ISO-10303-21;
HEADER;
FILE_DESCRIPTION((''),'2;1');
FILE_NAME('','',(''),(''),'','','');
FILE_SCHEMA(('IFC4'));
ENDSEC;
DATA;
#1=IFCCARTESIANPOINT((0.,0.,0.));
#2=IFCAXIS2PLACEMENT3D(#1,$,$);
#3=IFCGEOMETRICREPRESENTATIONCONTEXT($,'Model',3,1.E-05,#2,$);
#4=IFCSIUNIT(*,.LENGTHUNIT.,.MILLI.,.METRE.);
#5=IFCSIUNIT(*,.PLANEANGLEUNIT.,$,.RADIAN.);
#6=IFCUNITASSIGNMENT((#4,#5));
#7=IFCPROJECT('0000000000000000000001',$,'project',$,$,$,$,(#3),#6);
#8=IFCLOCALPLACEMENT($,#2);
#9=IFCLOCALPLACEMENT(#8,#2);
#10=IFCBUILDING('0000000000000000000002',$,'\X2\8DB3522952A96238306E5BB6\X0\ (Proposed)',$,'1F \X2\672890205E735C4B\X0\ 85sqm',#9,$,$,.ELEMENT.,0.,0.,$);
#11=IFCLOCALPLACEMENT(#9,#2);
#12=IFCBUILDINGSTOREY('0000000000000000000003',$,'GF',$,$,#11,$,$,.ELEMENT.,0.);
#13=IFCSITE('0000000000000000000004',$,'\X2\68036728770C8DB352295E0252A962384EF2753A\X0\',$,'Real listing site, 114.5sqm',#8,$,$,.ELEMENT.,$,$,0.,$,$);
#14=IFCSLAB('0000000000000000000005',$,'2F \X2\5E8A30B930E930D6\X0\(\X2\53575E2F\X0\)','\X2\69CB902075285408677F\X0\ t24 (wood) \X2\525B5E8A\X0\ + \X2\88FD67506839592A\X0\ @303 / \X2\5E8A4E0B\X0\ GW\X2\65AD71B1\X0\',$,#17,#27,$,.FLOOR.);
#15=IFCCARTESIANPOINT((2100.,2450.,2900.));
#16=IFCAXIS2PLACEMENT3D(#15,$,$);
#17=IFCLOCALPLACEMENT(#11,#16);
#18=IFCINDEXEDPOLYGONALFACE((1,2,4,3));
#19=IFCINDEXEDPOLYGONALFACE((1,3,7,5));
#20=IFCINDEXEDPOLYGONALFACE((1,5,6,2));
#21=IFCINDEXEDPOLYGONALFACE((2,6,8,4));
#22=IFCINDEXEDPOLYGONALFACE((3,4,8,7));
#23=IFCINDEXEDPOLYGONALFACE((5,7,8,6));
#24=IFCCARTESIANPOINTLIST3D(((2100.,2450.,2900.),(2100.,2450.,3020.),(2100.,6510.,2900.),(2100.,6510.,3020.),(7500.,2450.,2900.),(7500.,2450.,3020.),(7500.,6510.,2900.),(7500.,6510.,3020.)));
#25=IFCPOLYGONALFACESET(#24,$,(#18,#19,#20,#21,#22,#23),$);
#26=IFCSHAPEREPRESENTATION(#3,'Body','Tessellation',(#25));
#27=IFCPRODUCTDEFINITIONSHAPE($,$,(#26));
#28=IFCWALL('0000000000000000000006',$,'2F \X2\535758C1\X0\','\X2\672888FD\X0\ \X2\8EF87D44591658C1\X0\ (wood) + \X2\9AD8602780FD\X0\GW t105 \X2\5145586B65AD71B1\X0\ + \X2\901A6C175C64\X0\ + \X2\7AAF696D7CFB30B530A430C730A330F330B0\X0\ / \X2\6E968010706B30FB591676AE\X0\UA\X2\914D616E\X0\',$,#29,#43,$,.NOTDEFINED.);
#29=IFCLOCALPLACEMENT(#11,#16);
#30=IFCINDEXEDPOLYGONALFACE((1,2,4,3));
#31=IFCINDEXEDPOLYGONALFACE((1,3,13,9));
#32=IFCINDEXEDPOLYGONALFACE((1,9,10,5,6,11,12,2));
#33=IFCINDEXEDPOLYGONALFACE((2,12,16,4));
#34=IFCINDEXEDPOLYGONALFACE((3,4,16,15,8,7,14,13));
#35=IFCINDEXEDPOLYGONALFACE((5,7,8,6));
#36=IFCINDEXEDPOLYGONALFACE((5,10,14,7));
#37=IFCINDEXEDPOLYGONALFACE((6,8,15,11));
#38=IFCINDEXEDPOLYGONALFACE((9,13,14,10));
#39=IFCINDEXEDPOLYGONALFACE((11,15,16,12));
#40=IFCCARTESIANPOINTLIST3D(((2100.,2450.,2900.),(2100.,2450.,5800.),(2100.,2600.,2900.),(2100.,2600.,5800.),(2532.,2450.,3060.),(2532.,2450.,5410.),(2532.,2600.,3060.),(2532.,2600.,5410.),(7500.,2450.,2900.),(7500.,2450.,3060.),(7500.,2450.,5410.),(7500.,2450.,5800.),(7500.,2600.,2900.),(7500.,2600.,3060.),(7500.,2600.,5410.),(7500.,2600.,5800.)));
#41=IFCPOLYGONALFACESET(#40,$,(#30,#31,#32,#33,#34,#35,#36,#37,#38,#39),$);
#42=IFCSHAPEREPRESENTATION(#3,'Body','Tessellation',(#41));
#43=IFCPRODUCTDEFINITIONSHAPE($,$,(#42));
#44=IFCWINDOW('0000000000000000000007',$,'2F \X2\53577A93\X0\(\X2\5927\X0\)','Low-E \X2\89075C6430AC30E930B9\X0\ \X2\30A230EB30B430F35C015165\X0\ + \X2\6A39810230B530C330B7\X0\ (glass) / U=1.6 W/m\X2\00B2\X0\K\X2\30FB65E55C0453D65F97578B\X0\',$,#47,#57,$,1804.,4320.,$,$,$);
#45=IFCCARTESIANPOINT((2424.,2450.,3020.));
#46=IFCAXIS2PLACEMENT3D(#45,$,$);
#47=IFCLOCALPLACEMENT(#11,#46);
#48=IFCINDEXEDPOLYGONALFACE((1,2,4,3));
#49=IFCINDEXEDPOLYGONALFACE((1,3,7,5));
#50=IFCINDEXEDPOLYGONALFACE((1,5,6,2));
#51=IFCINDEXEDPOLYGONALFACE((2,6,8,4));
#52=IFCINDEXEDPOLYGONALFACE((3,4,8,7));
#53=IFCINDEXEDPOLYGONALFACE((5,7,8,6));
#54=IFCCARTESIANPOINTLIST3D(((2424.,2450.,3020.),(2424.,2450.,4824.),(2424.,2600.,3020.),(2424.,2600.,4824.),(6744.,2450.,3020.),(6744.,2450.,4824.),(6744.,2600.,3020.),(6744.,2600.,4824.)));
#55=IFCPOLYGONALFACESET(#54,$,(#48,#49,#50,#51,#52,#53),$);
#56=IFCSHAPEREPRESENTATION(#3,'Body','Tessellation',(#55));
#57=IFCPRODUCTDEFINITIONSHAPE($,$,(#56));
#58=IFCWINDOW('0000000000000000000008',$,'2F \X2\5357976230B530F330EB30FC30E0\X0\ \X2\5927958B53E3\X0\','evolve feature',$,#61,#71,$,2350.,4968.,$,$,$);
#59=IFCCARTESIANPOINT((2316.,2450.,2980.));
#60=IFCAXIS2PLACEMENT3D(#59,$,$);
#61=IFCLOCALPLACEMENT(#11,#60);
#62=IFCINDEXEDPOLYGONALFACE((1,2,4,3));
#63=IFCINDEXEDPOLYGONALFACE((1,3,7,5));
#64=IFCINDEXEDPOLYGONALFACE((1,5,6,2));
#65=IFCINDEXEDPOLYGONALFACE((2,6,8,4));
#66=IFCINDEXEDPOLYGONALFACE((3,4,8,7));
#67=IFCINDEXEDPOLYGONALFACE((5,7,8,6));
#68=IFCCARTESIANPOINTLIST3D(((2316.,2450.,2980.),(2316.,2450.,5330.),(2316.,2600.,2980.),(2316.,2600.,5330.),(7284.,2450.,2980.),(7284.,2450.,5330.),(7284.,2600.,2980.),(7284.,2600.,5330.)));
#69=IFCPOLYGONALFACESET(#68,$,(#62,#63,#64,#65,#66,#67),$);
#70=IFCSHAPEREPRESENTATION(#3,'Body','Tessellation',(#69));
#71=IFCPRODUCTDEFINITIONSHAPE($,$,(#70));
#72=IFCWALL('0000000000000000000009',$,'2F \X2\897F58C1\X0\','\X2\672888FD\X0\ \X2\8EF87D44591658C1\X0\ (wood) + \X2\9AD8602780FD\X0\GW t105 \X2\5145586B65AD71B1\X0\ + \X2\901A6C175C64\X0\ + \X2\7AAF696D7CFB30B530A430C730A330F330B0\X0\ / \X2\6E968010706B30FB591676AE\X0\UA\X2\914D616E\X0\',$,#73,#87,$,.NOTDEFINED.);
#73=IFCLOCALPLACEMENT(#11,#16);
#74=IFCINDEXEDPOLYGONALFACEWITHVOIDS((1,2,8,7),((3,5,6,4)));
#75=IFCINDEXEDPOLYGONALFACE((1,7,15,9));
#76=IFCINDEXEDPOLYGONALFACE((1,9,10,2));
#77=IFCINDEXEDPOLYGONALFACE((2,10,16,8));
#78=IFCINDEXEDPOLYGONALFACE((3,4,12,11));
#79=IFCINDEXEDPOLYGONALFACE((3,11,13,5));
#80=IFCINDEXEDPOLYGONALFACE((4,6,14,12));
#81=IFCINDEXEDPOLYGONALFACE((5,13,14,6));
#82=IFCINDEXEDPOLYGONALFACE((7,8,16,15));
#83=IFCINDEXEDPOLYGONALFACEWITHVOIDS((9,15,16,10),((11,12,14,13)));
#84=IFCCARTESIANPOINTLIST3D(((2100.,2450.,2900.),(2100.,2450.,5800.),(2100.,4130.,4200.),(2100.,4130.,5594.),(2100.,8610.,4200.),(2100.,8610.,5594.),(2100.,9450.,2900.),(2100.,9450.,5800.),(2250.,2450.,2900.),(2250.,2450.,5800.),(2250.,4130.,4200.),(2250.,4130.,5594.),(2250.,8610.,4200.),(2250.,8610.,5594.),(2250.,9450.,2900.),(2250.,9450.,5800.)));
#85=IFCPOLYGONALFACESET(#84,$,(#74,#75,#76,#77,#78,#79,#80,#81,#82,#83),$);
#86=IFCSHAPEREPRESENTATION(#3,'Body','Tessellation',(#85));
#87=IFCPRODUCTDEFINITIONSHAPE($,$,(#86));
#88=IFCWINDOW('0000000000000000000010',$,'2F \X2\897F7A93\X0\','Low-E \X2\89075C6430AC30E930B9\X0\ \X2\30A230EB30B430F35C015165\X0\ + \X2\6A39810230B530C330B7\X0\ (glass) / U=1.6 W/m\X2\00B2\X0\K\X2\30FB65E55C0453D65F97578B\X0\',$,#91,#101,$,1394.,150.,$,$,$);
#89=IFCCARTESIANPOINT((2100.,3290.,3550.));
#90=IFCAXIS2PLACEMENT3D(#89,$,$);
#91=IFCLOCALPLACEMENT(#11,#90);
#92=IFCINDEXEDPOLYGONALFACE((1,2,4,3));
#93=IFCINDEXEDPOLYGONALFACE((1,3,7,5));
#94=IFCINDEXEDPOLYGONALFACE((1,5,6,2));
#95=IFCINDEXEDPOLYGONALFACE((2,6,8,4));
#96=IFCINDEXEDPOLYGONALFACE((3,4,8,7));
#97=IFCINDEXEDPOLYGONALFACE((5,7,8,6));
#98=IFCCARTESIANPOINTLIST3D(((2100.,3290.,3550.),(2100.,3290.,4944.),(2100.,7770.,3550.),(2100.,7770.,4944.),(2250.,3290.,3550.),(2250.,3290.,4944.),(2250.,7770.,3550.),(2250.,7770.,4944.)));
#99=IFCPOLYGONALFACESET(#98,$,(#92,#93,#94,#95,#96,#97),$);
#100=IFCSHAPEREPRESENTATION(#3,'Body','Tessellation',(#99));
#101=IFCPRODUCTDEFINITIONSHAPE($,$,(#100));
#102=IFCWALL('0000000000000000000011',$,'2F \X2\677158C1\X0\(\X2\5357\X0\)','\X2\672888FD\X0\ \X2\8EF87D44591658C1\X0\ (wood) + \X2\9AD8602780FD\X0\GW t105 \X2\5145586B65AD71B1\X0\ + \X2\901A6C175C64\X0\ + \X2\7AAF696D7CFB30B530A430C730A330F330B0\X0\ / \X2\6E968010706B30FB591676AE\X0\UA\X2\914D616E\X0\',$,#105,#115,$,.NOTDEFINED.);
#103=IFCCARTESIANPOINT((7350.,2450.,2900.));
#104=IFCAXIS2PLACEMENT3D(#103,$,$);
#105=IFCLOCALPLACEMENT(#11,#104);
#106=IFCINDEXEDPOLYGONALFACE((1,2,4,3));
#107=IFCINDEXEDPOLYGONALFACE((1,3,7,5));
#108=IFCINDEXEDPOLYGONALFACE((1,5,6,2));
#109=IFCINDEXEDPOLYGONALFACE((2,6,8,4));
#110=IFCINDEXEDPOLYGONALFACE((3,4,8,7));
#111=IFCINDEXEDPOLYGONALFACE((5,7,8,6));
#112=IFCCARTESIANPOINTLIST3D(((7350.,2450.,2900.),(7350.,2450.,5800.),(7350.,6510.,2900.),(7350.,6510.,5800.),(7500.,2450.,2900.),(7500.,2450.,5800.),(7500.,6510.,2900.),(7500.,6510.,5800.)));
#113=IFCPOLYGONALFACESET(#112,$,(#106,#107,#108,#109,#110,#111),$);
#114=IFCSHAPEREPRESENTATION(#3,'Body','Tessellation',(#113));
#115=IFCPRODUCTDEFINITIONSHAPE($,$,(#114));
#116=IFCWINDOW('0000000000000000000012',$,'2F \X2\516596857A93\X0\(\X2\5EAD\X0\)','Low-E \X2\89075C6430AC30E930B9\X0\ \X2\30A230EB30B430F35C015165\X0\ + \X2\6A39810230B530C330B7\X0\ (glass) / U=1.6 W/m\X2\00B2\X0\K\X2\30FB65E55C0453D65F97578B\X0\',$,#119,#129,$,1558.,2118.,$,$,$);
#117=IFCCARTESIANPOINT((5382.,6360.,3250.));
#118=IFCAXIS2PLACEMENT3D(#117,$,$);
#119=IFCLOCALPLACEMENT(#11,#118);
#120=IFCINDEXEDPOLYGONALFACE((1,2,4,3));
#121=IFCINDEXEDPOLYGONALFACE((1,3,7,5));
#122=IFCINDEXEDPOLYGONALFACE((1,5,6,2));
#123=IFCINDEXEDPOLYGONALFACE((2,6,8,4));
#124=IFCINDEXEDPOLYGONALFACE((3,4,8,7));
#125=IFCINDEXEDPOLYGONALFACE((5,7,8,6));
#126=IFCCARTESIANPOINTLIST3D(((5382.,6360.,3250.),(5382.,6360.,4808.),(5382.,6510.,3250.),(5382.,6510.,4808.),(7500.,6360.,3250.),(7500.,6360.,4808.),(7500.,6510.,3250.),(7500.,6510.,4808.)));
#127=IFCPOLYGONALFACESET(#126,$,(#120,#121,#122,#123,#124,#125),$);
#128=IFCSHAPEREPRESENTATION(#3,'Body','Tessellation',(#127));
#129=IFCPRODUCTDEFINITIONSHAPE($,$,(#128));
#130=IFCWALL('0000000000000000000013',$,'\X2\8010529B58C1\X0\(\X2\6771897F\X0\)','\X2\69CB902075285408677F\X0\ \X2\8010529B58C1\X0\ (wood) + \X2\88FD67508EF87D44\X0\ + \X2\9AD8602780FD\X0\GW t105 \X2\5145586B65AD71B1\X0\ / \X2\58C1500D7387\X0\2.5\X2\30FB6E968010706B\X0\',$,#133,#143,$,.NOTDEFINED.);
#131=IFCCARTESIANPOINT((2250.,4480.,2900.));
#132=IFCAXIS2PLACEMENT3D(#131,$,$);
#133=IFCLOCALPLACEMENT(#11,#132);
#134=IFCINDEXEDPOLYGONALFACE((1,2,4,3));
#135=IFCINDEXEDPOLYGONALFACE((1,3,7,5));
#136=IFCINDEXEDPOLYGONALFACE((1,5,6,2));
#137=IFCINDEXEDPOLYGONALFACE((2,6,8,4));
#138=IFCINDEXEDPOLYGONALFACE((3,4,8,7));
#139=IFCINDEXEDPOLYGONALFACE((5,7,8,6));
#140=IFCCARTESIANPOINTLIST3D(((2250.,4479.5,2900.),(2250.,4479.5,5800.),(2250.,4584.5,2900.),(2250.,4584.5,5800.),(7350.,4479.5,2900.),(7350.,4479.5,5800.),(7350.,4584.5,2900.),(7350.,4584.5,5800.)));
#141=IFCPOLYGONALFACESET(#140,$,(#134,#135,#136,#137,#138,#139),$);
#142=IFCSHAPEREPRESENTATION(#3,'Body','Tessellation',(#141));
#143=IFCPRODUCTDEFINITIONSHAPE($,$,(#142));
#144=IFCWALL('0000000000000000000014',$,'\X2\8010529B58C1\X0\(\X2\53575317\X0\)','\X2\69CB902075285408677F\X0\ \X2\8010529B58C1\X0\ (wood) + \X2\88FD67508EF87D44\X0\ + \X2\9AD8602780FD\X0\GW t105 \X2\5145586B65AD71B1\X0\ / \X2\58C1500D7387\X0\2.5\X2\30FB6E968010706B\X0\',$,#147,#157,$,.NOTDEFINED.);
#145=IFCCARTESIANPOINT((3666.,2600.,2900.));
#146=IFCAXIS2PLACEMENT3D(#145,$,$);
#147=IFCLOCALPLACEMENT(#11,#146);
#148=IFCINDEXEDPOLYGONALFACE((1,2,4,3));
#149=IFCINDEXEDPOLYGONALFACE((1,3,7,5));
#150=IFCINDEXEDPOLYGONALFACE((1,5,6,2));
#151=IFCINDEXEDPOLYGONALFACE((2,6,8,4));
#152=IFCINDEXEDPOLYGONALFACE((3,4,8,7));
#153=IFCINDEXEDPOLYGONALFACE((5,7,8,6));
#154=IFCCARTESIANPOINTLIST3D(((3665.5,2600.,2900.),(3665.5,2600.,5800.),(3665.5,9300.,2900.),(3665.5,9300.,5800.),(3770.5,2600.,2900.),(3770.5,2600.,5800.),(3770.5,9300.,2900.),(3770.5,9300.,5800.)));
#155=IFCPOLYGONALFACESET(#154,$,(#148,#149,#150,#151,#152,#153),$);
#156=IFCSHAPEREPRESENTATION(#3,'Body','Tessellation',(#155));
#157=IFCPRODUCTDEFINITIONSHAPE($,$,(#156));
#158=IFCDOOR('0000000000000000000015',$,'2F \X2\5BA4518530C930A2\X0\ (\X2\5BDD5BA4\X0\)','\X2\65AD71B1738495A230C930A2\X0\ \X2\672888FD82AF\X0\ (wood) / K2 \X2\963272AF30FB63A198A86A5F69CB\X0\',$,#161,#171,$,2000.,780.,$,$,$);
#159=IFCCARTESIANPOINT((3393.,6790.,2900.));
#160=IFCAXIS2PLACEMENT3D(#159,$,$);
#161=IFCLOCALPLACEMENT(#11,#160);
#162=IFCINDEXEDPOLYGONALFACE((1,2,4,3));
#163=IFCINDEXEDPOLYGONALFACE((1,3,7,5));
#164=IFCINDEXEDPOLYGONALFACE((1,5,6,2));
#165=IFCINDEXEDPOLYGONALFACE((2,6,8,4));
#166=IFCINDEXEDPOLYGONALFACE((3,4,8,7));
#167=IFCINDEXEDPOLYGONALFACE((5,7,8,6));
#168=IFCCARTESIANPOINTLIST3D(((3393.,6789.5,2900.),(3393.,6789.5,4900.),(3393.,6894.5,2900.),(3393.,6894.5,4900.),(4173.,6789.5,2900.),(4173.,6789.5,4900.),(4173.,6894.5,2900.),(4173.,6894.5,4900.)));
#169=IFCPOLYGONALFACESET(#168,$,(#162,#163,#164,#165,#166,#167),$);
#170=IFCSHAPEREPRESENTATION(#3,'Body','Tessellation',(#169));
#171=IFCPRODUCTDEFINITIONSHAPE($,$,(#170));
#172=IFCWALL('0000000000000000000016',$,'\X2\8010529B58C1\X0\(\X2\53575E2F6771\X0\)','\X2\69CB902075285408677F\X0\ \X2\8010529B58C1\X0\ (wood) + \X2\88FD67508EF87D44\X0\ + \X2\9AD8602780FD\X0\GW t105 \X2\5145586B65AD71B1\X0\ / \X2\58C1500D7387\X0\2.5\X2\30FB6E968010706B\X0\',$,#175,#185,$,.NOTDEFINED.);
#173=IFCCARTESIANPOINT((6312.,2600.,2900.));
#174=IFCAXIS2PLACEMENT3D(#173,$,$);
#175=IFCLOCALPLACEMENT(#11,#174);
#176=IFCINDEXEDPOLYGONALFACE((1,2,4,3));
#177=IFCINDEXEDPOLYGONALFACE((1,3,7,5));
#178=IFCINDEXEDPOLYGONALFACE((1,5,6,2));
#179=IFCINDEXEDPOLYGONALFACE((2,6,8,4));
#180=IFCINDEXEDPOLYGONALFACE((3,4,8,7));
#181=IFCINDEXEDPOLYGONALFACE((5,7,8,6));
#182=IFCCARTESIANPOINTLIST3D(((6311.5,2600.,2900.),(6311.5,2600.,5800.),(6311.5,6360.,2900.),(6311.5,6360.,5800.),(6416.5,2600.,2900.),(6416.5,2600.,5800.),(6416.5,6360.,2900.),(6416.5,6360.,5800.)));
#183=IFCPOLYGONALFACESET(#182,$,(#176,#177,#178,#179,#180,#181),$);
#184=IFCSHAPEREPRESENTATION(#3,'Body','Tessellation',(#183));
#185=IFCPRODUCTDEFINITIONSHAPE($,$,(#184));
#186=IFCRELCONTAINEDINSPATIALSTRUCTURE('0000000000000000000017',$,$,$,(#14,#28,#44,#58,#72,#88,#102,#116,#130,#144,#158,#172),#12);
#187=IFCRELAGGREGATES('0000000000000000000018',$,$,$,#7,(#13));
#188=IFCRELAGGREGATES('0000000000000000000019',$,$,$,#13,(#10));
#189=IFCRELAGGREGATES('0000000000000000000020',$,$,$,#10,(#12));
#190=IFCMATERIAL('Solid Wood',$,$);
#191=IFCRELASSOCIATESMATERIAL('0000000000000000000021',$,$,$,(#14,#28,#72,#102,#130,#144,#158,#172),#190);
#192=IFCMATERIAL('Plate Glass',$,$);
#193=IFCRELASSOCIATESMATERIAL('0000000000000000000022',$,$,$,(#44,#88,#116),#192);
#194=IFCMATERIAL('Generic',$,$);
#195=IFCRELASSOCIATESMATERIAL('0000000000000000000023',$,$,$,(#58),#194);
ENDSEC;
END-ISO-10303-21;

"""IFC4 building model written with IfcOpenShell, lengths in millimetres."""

from ifc_helpers import new_model, si_unit, frame, frame_2d, origin, place, context, project, spatial, rectangle, extrude, material, element, fill, save


model = new_model("IFC4")

# Units and contexts
model_context = context("Model", 3, precision=1e-05, world=origin())
ifc_project = project(units=[si_unit("LENGTHUNIT", "METRE", prefix="MILLI"), si_unit("PLANEANGLEUNIT", "RADIAN")], contexts=[model_context])

# Site, building, storey
site_placement = place(None, origin())
site = spatial("IfcSite", under=ifc_project, at=site_placement, Name="栃木県足利市助戸仲町", ObjectType="Real listing site, 114.5sqm", CompositionType="ELEMENT", RefElevation=0.0)
building_placement = place(site_placement, origin())
building = spatial("IfcBuilding", under=site, at=building_placement, Name="足利助戸の家 (Proposed)", ObjectType="1F 木造平屋 85sqm", CompositionType="ELEMENT", ElevationOfRefHeight=0.0, ElevationOfTerrain=0.0)
storey_placement = place(building_placement, origin())
storey = spatial("IfcBuildingStorey", under=building, at=storey_placement, Name="GF", CompositionType="ELEMENT", Elevation=0.0)

# Slab
ifc_material_1 = material(Name="Solid Wood")
slab_placement = place(storey_placement, frame((2100.0, 2450.0, 2900.0)))
element("IfcSlab", 1, at=slab_placement, inside=storey, material=ifc_material_1, Name="2F 床スラブ(南帯)", Description="構造用合板 t24 (wood) 剛床 + 製材根太 @303 / 床下 GW断熱", PredefinedType="FLOOR", context=model_context, shape_type="SweptSolid", body=[
    extrude(rectangle(XDim=5400.0, YDim=4060.0, at=frame_2d((2700.0, 2030.0))), frame((2100.0, 2450.0, 2900.0)), (0.0, 0.0, 1.0), 120.0),
])

# Wall, openings, windows
wall_1_placement = place(storey_placement, frame((2100.0, 2450.0, 2900.0)))
wall_1 = element("IfcWall", 2, at=wall_1_placement, inside=storey, material=ifc_material_1, Name="2F 南壁", Description="木製 軸組外壁 (wood) + 高性能GW t105 充填断熱 + 通気層 + 窯業系サイディング / 準耐火・外皮UA配慮", PredefinedType="NOTDEFINED", context=model_context, shape_type="SweptSolid", body=[
    extrude(rectangle(XDim=5400.0, YDim=150.0, at=frame_2d((2700.0, 75.0))), frame((2100.0, 2450.0, 2900.0)), (0.0, 0.0, 1.0), 2900.0),
])
opening_1_placement = place(storey_placement, frame((2424.0, 2450.0, 3020.0)))
opening_1 = element("IfcOpeningElement", 3, at=opening_1_placement, cuts=wall_1, PredefinedType="NOTDEFINED", context=model_context, shape_type="SweptSolid", body=[
    extrude(rectangle(XDim=4320.0, YDim=150.0, at=frame_2d((2160.0, 75.0))), frame((2424.0, 2450.0, 3020.0)), (0.0, 0.0, 1.0), 1804.0),
])
opening_2_placement = place(storey_placement, frame((2316.0, 2450.0, 2980.0)))
opening_2 = element("IfcOpeningElement", 4, at=opening_2_placement, cuts=wall_1, PredefinedType="NOTDEFINED", context=model_context, shape_type="SweptSolid", body=[
    extrude(rectangle(XDim=4968.0, YDim=150.0, at=frame_2d((2484.0, 75.0))), frame((2316.0, 2450.0, 2980.0)), (0.0, 0.0, 1.0), 2350.0),
])
ifc_material_2 = material(Name="Plate Glass")
window_1_placement = place(storey_placement, frame((2424.0, 2450.0, 3020.0)))
window_1 = element("IfcWindow", 5, at=window_1_placement, inside=storey, material=ifc_material_2, Name="2F 南窓(大)", Description="Low-E 複層ガラス アルゴン封入 + 樹脂サッシ (glass) / U=1.6 W/m²K・日射取得型", OverallHeight=1804.0, OverallWidth=4320.0, context=model_context, shape_type="SweptSolid", body=[
    extrude(rectangle(XDim=4320.0, YDim=150.0, at=frame_2d((2160.0, 75.0))), frame((2424.0, 2450.0, 3020.0)), (0.0, 0.0, 1.0), 1804.0),
])
fill(opening_1, window_1)
ifc_material_3 = material(Name="Generic")
window_2_placement = place(storey_placement, frame((2316.0, 2450.0, 2980.0)))
window_2 = element("IfcWindow", 6, at=window_2_placement, inside=storey, material=ifc_material_3, Name="2F 南面サンルーム 大開口", Description="evolve feature", OverallHeight=2350.0, OverallWidth=4968.0, context=model_context, shape_type="SweptSolid", body=[
    extrude(rectangle(XDim=4968.0, YDim=150.0, at=frame_2d((2484.0, 75.0))), frame((2316.0, 2450.0, 2980.0)), (0.0, 0.0, 1.0), 2350.0),
])
fill(opening_2, window_2)

# Walls, openings, windows
wall_2_placement = place(storey_placement, frame((2100.0, 2450.0, 2900.0)))
wall_2 = element("IfcWall", 7, at=wall_2_placement, inside=storey, material=ifc_material_1, Name="2F 西壁", Description="木製 軸組外壁 (wood) + 高性能GW t105 充填断熱 + 通気層 + 窯業系サイディング / 準耐火・外皮UA配慮", PredefinedType="NOTDEFINED", context=model_context, shape_type="SweptSolid", body=[
    extrude(rectangle(XDim=150.0, YDim=7000.0, at=frame_2d((75.0, 3500.0))), frame((2100.0, 2450.0, 2900.0)), (0.0, 0.0, 1.0), 2900.0),
])
opening_3_placement = place(storey_placement, frame((2100.0, 3290.0, 3550.0)))
opening_3 = element("IfcOpeningElement", 8, at=opening_3_placement, cuts=wall_2, PredefinedType="NOTDEFINED", context=model_context, shape_type="SweptSolid", body=[
    extrude(rectangle(XDim=150.0, YDim=4480.0, at=frame_2d((75.0, 2240.0))), frame((2100.0, 3290.0, 3550.0)), (0.0, 0.0, 1.0), 1394.0),
])
window_3_placement = place(storey_placement, frame((2100.0, 3290.0, 3550.0)))
window_3 = element("IfcWindow", 9, at=window_3_placement, inside=storey, material=ifc_material_2, Name="2F 西窓", Description="Low-E 複層ガラス アルゴン封入 + 樹脂サッシ (glass) / U=1.6 W/m²K・日射取得型", OverallHeight=1394.0, OverallWidth=150.0, context=model_context, shape_type="SweptSolid", body=[
    extrude(rectangle(XDim=150.0, YDim=4480.0, at=frame_2d((75.0, 2240.0))), frame((2100.0, 3290.0, 3550.0)), (0.0, 0.0, 1.0), 1394.0),
])
fill(opening_3, window_3)
wall_3_placement = place(storey_placement, frame((7350.0, 2450.0, 2900.0)))
wall_3 = element("IfcWall", 10, at=wall_3_placement, inside=storey, material=ifc_material_1, Name="2F 東壁(南)", Description="木製 軸組外壁 (wood) + 高性能GW t105 充填断熱 + 通気層 + 窯業系サイディング / 準耐火・外皮UA配慮", PredefinedType="NOTDEFINED", context=model_context, shape_type="SweptSolid", body=[
    extrude(rectangle(XDim=150.0, YDim=4060.0, at=frame_2d((75.0, 2030.0))), frame((7350.0, 2450.0, 2900.0)), (0.0, 0.0, 1.0), 2900.0),
])
opening_4_placement = place(storey_placement, frame((5382.0, 6360.0, 3250.0)))
opening_4 = element("IfcOpeningElement", 11, at=opening_4_placement, cuts=wall_3, PredefinedType="NOTDEFINED", context=model_context, shape_type="SweptSolid", body=[
    extrude(rectangle(XDim=2118.0, YDim=150.0, at=frame_2d((1059.0, 75.0))), frame((5382.0, 6360.0, 3250.0)), (0.0, 0.0, 1.0), 1558.0),
])
window_4_placement = place(storey_placement, frame((5382.0, 6360.0, 3250.0)))
window_4 = element("IfcWindow", 12, at=window_4_placement, inside=storey, material=ifc_material_2, Name="2F 入隅窓(庭)", Description="Low-E 複層ガラス アルゴン封入 + 樹脂サッシ (glass) / U=1.6 W/m²K・日射取得型", OverallHeight=1558.0, OverallWidth=2118.0, context=model_context, shape_type="SweptSolid", body=[
    extrude(rectangle(XDim=2118.0, YDim=150.0, at=frame_2d((1059.0, 75.0))), frame((5382.0, 6360.0, 3250.0)), (0.0, 0.0, 1.0), 1558.0),
])
fill(opening_4, window_4)

# Wall
wall_4_placement = place(storey_placement, frame((2250.0, 4480.0, 2900.0)))
element("IfcWall", 13, at=wall_4_placement, inside=storey, material=ifc_material_1, Name="耐力壁(東西)", Description="構造用合板 耐力壁 (wood) + 製材軸組 + 高性能GW t105 充填断熱 / 壁倍率2.5・準耐火", PredefinedType="NOTDEFINED", context=model_context, shape_type="SweptSolid", body=[
    extrude(rectangle(XDim=5100.0, YDim=105.0, at=frame_2d((2550.0, 52.0))), frame((2250.0, 4480.0, 2900.0)), (0.0, 0.0, 1.0), 2900.0),
])

# Wall, opening, door
wall_5_placement = place(storey_placement, frame((3666.0, 2600.0, 2900.0)))
wall_5 = element("IfcWall", 14, at=wall_5_placement, inside=storey, material=ifc_material_1, Name="耐力壁(南北)", Description="構造用合板 耐力壁 (wood) + 製材軸組 + 高性能GW t105 充填断熱 / 壁倍率2.5・準耐火", PredefinedType="NOTDEFINED", context=model_context, shape_type="SweptSolid", body=[
    extrude(rectangle(XDim=105.0, YDim=6700.0, at=frame_2d((52.0, 3350.0))), frame((3666.0, 2600.0, 2900.0)), (0.0, 0.0, 1.0), 2900.0),
])
opening_5_placement = place(storey_placement, frame((3393.0, 6790.0, 2900.0)))
opening_5 = element("IfcOpeningElement", 15, at=opening_5_placement, cuts=wall_5, PredefinedType="NOTDEFINED", context=model_context, shape_type="SweptSolid", body=[
    extrude(rectangle(XDim=780.0, YDim=105.0, at=frame_2d((390.0, 52.0))), frame((3393.0, 6790.0, 2900.0)), (0.0, 0.0, 1.0), 2000.0),
])
door_placement = place(storey_placement, frame((3393.0, 6790.0, 2900.0)))
door = element("IfcDoor", 16, at=door_placement, inside=storey, material=ifc_material_1, Name="2F 室内ドア (寝室)", Description="断熱玄関ドア 木製芯 (wood) / K2 防犯・採風機構", OverallHeight=2000.0, OverallWidth=780.0, context=model_context, shape_type="SweptSolid", body=[
    extrude(rectangle(XDim=780.0, YDim=105.0, at=frame_2d((390.0, 52.0))), frame((3393.0, 6790.0, 2900.0)), (0.0, 0.0, 1.0), 2000.0),
])
fill(opening_5, door)

# Wall
wall_6_placement = place(storey_placement, frame((6312.0, 2600.0, 2900.0)))
element("IfcWall", 17, at=wall_6_placement, inside=storey, material=ifc_material_1, Name="耐力壁(南帯東)", Description="構造用合板 耐力壁 (wood) + 製材軸組 + 高性能GW t105 充填断熱 / 壁倍率2.5・準耐火", PredefinedType="NOTDEFINED", context=model_context, shape_type="SweptSolid", body=[
    extrude(rectangle(XDim=105.0, YDim=3760.0, at=frame_2d((52.0, 1880.0))), frame((6312.0, 2600.0, 2900.0)), (0.0, 0.0, 1.0), 2900.0),
])

save(model, "model.ifc")
